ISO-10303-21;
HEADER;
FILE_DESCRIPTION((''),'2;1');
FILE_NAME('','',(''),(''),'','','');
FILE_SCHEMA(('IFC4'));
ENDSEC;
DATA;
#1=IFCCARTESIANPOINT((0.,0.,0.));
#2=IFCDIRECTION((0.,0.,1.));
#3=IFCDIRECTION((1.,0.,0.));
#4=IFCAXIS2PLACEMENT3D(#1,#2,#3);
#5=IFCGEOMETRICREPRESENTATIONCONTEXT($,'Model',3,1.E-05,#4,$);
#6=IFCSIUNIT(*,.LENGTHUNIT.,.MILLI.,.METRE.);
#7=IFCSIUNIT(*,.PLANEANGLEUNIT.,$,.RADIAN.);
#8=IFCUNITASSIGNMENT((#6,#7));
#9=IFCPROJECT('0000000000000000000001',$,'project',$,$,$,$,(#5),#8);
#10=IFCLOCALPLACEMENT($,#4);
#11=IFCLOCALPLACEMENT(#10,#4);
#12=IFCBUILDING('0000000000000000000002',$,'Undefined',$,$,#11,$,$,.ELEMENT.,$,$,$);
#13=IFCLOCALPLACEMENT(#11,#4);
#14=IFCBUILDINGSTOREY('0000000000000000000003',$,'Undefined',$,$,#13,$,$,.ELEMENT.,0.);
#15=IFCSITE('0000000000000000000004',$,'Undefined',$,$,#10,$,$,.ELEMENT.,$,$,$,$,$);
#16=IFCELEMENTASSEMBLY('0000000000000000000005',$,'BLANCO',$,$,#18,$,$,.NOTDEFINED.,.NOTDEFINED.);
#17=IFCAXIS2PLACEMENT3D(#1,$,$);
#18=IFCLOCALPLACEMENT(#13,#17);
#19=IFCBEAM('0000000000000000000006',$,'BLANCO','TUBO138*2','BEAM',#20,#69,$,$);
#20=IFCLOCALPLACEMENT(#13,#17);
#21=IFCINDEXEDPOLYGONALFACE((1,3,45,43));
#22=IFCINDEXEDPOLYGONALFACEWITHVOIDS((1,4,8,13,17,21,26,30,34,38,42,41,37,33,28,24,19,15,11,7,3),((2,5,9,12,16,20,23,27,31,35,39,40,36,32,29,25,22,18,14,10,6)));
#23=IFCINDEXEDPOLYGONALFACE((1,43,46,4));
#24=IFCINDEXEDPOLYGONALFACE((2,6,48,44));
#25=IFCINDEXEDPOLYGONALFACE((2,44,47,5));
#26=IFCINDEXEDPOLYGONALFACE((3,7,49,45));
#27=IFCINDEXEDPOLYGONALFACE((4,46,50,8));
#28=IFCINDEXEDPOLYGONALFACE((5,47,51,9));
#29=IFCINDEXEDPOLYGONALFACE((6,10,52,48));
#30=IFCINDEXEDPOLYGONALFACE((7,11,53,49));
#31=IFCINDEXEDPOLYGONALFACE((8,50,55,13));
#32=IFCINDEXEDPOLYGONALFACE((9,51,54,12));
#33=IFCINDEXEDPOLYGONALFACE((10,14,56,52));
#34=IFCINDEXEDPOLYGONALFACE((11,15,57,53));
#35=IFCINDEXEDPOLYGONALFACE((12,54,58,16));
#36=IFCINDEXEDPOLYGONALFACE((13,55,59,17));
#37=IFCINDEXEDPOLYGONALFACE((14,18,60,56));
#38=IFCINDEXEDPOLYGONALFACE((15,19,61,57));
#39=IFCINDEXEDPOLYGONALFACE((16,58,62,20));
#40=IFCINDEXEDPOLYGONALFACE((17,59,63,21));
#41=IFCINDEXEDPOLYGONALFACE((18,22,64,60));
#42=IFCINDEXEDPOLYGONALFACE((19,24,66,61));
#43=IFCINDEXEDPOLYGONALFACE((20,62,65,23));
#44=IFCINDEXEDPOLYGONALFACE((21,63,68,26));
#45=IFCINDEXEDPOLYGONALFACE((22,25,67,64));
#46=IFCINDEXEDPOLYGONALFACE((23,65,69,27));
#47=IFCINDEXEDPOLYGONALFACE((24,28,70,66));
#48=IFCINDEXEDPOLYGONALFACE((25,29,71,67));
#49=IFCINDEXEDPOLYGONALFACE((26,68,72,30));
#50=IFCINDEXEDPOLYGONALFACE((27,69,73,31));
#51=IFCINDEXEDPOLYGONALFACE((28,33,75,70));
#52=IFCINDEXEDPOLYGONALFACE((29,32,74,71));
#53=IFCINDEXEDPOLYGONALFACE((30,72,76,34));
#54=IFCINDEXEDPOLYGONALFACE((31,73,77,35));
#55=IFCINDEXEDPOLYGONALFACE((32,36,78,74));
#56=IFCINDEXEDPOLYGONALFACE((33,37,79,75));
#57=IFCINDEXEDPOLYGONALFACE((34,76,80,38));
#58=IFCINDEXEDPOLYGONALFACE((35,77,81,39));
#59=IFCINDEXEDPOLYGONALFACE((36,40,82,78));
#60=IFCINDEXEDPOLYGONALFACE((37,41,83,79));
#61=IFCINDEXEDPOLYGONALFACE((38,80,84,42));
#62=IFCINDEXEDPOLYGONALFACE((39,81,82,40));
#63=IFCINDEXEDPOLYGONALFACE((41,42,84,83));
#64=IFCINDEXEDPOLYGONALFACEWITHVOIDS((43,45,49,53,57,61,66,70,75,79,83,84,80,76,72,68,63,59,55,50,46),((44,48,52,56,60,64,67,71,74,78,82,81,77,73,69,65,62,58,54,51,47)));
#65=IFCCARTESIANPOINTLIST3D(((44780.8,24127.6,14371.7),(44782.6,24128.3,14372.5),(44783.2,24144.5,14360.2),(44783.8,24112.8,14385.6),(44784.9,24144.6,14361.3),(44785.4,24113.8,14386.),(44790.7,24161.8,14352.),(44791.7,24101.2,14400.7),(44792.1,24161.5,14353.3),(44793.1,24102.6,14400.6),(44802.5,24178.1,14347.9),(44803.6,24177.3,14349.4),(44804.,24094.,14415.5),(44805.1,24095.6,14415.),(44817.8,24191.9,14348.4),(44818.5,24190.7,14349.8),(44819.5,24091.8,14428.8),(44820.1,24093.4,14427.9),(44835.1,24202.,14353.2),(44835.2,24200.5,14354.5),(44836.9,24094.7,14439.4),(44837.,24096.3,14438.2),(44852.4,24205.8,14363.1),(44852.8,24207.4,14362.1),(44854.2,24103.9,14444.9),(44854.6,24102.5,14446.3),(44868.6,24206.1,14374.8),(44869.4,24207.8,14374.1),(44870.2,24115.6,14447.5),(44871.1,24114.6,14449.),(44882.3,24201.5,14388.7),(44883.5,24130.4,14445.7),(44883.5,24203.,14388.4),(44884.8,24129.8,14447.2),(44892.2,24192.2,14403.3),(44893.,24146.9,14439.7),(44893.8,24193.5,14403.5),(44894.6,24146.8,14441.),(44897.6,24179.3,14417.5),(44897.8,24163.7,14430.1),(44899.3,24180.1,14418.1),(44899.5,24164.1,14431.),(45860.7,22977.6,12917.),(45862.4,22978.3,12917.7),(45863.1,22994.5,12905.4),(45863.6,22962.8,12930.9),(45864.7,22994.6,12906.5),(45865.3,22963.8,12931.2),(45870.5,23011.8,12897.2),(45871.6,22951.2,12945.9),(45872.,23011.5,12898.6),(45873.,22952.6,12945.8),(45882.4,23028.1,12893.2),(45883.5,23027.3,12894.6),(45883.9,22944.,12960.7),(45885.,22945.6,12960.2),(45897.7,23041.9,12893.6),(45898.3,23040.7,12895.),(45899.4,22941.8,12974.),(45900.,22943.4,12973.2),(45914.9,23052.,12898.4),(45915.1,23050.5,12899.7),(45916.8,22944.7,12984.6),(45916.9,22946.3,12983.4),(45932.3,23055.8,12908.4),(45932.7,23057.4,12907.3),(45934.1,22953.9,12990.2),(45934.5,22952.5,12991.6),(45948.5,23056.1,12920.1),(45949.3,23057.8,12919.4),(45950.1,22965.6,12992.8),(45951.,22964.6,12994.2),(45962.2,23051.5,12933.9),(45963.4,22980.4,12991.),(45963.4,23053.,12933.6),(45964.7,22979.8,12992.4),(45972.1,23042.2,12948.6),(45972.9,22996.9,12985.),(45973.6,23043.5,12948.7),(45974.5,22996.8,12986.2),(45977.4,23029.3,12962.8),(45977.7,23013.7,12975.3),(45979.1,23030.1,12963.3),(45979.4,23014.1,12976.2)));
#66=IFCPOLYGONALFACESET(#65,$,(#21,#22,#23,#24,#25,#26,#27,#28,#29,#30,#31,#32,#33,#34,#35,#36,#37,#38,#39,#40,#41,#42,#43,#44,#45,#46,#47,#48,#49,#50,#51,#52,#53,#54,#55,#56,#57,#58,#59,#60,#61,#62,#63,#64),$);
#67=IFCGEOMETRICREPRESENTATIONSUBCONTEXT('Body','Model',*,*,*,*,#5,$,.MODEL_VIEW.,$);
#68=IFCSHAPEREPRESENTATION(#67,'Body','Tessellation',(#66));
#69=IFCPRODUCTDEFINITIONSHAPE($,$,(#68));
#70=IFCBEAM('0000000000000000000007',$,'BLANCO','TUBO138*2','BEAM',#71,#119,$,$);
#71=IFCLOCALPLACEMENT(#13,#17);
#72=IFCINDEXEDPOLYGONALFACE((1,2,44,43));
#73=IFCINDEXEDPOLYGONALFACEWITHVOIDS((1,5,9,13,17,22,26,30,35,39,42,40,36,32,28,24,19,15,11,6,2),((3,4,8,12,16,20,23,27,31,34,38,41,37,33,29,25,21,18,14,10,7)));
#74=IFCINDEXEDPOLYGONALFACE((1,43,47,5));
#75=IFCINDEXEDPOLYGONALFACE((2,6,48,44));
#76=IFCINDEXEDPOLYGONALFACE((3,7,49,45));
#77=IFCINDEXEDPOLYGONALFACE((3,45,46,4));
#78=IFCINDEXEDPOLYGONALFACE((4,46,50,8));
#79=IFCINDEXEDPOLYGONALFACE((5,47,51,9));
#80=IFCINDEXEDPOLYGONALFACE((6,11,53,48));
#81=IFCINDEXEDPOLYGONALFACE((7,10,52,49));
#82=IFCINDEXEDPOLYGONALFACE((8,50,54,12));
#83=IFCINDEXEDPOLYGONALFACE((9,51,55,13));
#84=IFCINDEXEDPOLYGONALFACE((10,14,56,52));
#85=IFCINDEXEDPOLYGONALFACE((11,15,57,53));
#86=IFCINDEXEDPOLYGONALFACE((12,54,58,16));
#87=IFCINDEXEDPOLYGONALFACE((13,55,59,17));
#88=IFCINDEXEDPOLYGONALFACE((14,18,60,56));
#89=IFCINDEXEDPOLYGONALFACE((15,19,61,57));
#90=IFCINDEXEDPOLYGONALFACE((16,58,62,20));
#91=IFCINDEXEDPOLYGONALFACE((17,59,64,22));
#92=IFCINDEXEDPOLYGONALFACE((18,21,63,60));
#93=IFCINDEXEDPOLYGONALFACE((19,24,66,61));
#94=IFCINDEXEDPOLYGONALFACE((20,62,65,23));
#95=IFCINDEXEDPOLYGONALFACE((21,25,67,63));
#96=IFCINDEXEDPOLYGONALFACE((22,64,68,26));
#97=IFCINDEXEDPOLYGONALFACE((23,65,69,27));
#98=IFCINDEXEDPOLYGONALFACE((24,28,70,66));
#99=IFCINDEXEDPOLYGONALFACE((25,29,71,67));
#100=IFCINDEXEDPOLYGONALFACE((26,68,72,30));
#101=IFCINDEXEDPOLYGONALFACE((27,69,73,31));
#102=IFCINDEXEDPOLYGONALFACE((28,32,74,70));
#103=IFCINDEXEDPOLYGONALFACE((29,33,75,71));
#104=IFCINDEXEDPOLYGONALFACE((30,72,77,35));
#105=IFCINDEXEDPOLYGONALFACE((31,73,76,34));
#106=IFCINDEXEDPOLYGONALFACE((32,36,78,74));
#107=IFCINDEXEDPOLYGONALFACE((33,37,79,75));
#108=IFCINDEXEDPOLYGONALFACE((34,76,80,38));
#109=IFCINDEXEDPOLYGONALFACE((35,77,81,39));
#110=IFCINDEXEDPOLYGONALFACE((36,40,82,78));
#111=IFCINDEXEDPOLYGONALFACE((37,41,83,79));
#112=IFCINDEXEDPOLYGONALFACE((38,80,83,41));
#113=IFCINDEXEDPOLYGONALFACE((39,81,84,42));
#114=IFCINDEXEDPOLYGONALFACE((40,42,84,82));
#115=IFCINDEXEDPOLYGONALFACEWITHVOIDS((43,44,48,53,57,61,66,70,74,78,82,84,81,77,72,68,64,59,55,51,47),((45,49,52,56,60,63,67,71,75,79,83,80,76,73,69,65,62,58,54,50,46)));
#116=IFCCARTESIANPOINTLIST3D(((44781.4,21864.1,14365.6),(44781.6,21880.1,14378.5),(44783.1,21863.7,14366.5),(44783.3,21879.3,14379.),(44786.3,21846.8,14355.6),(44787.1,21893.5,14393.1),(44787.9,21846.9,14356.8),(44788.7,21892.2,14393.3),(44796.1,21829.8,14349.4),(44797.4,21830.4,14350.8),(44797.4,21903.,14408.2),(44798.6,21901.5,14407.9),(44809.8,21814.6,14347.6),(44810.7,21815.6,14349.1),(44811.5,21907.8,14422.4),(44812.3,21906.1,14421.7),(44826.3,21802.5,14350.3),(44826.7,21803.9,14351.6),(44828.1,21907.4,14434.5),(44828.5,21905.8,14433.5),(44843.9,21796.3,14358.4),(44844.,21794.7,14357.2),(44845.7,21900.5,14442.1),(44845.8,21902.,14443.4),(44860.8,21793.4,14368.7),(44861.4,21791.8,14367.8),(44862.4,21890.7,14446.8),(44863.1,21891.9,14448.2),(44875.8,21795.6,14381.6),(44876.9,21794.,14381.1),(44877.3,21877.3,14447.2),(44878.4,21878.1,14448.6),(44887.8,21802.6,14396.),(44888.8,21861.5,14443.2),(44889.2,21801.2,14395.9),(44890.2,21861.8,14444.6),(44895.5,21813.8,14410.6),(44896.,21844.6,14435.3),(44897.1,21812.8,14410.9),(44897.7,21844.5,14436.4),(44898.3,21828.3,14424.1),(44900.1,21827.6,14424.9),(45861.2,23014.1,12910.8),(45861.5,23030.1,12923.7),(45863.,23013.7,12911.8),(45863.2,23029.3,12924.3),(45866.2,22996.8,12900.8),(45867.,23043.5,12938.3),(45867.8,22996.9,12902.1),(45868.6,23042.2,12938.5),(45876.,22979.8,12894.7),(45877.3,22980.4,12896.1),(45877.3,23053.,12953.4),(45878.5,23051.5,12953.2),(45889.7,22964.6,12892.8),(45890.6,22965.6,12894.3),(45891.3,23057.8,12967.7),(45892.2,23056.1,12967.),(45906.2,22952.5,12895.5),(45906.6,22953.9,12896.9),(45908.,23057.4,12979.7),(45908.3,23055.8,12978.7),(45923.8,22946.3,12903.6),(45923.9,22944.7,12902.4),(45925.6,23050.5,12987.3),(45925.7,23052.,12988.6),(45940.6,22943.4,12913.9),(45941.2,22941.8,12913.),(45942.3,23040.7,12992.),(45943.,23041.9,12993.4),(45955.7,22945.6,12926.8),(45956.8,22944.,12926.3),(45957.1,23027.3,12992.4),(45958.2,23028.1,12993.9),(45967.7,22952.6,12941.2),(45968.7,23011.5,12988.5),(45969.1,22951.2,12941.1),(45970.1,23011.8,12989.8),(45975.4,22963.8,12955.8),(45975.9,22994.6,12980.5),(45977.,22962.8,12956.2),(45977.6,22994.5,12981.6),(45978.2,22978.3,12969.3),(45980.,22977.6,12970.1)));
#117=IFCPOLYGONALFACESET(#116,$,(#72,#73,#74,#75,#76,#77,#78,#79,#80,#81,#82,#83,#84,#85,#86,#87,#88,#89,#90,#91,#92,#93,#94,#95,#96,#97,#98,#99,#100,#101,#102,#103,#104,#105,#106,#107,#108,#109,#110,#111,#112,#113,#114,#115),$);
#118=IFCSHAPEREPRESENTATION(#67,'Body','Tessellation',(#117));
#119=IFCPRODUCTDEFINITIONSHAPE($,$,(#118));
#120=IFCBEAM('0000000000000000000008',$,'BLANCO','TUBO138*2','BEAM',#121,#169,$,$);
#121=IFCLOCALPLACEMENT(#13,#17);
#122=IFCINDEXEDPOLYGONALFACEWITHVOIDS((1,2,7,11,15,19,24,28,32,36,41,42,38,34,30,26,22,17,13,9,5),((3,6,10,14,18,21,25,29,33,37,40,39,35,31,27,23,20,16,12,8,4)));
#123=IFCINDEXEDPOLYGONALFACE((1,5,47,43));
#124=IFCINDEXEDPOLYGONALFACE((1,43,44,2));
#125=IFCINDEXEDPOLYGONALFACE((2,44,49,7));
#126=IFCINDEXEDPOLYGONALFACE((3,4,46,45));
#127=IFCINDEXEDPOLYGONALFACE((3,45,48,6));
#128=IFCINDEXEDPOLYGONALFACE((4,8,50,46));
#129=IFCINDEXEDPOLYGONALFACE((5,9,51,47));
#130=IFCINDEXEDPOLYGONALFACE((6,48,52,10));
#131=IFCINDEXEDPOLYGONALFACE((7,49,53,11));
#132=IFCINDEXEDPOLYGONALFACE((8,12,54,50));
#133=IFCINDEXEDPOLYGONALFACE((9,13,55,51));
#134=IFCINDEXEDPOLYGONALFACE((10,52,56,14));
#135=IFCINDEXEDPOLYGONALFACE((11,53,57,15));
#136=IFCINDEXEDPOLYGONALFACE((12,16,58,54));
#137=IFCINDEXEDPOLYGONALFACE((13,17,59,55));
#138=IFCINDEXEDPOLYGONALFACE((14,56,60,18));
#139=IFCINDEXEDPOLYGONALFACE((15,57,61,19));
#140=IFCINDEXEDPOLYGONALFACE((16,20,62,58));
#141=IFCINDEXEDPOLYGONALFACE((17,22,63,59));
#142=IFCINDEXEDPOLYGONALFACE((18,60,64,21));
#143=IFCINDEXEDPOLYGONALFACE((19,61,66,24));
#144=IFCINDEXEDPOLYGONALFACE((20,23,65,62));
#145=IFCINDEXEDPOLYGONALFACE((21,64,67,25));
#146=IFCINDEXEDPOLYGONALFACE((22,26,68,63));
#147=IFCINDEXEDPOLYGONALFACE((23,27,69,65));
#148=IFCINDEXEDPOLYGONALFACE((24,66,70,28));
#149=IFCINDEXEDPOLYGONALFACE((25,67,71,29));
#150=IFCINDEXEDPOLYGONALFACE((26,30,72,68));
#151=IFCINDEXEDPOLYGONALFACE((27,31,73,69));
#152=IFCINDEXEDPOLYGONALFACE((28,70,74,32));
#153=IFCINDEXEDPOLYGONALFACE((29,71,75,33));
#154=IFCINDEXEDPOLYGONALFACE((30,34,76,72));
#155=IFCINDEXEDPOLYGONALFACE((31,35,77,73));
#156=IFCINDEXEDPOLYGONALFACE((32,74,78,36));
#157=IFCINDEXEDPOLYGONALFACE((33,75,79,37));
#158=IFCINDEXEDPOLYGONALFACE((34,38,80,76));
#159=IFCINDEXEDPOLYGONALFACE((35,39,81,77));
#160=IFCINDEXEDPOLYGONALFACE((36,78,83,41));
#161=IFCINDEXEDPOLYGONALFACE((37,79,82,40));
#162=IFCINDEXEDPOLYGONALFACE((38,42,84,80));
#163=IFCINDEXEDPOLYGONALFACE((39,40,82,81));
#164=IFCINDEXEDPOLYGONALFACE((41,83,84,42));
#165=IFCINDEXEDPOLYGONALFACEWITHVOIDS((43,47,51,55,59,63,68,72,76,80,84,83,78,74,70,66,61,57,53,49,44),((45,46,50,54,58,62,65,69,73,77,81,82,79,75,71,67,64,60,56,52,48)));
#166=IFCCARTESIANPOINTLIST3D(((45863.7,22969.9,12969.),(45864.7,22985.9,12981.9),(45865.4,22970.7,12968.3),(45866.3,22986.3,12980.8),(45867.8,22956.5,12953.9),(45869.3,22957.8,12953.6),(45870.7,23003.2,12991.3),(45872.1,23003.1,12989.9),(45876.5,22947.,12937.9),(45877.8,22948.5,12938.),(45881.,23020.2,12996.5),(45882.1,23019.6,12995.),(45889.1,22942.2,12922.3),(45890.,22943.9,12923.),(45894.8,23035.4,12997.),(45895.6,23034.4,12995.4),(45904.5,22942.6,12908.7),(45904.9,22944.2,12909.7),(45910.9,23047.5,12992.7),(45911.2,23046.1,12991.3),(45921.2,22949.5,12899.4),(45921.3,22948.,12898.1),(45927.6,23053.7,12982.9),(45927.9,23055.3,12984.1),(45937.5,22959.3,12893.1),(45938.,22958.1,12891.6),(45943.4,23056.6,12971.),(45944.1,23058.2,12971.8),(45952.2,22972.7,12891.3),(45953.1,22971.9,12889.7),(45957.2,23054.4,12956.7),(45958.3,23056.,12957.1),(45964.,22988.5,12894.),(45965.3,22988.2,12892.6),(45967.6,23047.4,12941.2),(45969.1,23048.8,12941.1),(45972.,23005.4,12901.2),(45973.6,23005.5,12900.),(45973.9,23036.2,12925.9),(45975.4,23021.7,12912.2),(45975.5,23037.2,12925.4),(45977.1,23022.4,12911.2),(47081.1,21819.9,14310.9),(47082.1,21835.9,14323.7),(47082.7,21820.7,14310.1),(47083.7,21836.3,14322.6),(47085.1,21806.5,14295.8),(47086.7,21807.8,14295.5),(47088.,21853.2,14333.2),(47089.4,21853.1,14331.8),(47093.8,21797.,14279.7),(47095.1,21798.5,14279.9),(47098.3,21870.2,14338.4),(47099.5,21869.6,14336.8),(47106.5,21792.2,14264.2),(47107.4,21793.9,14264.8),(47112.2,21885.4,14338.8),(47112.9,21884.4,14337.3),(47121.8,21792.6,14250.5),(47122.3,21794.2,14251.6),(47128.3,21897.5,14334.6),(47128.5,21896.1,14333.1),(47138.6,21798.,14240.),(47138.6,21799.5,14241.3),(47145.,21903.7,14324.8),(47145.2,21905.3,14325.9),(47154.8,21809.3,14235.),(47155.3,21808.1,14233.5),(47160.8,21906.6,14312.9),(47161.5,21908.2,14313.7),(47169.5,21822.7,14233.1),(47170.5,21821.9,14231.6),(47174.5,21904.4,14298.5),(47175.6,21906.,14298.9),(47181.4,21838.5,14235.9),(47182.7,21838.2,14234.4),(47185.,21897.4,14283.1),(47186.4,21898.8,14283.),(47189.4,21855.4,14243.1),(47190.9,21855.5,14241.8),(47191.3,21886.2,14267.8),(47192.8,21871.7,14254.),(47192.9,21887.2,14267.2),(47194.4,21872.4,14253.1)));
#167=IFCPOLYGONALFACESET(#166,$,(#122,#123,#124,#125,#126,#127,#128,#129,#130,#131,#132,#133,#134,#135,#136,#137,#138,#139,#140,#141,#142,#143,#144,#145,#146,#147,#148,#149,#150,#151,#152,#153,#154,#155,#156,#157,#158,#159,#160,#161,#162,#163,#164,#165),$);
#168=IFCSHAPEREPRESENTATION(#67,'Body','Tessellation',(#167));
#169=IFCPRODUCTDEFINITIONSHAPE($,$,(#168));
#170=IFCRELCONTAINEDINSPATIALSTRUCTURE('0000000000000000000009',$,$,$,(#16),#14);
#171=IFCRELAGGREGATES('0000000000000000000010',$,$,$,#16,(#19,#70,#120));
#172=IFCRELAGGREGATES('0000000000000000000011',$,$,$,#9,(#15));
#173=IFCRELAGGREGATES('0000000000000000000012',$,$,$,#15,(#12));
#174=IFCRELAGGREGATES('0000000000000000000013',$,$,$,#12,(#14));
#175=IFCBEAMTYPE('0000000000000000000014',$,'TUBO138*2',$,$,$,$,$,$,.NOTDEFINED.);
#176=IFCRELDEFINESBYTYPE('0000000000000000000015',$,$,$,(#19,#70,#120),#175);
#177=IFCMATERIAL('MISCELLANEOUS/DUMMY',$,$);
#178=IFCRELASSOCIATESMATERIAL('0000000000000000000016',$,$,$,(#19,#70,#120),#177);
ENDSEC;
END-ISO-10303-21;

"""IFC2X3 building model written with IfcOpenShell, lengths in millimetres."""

from ifc_helpers import new_model, si_unit, frame, origin_with_axes, origin_2d_with_axis, place, context, subcontext, project, spatial, hollow_circle, extrude, material, type_object, element, aggregate, save


model = new_model("IFC2X3")

# Units and contexts
model_context = context("Model", 3, precision=1e-05, world=origin_with_axes())
body_context = subcontext(model_context, "Body", "Model", "MODEL_VIEW")
ifc_project = project(units=[si_unit("LENGTHUNIT", "METRE", prefix="MILLI"), si_unit("PLANEANGLEUNIT", "RADIAN")], contexts=[model_context])

# Site, building, storey
site_placement = place(None, origin_with_axes())
site = spatial("IfcSite", under=ifc_project, at=site_placement, Name="Undefined", CompositionType="ELEMENT")
building_placement = place(site_placement, origin_with_axes())
building = spatial("IfcBuilding", under=site, at=building_placement, Name="Undefined", CompositionType="ELEMENT")
storey_placement = place(building_placement, origin_with_axes())
storey = spatial("IfcBuildingStorey", under=building, at=storey_placement, Name="Undefined", CompositionType="ELEMENT", Elevation=0.0)

# Element assembly, beams
assembly_placement = place(storey_placement, origin_with_axes())
assembly = element("IfcElementAssembly", 1, at=assembly_placement, inside=storey, Name="BLANCO", AssemblyPlace="NOTDEFINED", PredefinedType="NOTDEFINED")
ifc_material = material(Name="MISCELLANEOUS/DUMMY")
beam_type = type_object("IfcBeamType", Name="TUBO138*2", PredefinedType="NOTDEFINED")
beam_1_placement = place(assembly_placement, frame((45920.3, 23000.0, 12943.5), z_axis=(-0.497966, 0.461316, -0.734314), x_axis=(-0.503224, 0.535899, 0.677922)))
beam_1 = element("IfcBeam", 2, at=beam_1_placement, type_object=beam_type, material=ifc_material, Name="BLANCO", Description="TUBO138*2", ObjectType="BEAM", context=body_context, shape_type="SweptSolid", body=[
    extrude(hollow_circle(Radius=69.0, WallThickness=2.0, at=origin_2d_with_axis()), frame((2145.9, 0.0, 0.0), z_axis=(-1.0, 0.0, 0.0), x_axis=(0.0, -1.0, 0.0)), (0.0, 0.0, 1.0), 2145.9),
])
beam_2_placement = place(assembly_placement, frame((45920.3, 23000.0, 12943.5), z_axis=(-0.497966, -0.461316, -0.734314), x_axis=(-0.503224, -0.535899, 0.677922)))
beam_2 = element("IfcBeam", 3, at=beam_2_placement, type_object=beam_type, material=ifc_material, Name="BLANCO", Description="TUBO138*2", ObjectType="BEAM", context=body_context, shape_type="SweptSolid", body=[
    extrude(hollow_circle(Radius=69.0, WallThickness=2.0, at=origin_2d_with_axis()), frame((2145.9, 0.0, 0.0), z_axis=(-1.0, 0.0, 0.0), x_axis=(0.0, -1.0, 0.0)), (0.0, 0.0, 1.0), 2145.9),
])
beam_3_placement = place(assembly_placement, frame((45920.3, 23000.0, 12943.5), z_axis=(0.423552, -0.461316, -0.77961), x_axis=(0.567282, -0.535899, 0.625303)))
beam_3 = element("IfcBeam", 4, at=beam_3_placement, type_object=beam_type, material=ifc_material, Name="BLANCO", Description="TUBO138*2", ObjectType="BEAM", context=body_context, shape_type="SweptSolid", body=[
    extrude(hollow_circle(Radius=69.0, WallThickness=2.0, at=origin_2d_with_axis()), frame((2145.9, 0.0, 0.0), z_axis=(-1.0, 0.0, 0.0), x_axis=(0.0, -1.0, 0.0)), (0.0, 0.0, 1.0), 2145.9),
])
aggregate(assembly, [beam_1, beam_2, beam_3])

save(model, "model.ifc")
